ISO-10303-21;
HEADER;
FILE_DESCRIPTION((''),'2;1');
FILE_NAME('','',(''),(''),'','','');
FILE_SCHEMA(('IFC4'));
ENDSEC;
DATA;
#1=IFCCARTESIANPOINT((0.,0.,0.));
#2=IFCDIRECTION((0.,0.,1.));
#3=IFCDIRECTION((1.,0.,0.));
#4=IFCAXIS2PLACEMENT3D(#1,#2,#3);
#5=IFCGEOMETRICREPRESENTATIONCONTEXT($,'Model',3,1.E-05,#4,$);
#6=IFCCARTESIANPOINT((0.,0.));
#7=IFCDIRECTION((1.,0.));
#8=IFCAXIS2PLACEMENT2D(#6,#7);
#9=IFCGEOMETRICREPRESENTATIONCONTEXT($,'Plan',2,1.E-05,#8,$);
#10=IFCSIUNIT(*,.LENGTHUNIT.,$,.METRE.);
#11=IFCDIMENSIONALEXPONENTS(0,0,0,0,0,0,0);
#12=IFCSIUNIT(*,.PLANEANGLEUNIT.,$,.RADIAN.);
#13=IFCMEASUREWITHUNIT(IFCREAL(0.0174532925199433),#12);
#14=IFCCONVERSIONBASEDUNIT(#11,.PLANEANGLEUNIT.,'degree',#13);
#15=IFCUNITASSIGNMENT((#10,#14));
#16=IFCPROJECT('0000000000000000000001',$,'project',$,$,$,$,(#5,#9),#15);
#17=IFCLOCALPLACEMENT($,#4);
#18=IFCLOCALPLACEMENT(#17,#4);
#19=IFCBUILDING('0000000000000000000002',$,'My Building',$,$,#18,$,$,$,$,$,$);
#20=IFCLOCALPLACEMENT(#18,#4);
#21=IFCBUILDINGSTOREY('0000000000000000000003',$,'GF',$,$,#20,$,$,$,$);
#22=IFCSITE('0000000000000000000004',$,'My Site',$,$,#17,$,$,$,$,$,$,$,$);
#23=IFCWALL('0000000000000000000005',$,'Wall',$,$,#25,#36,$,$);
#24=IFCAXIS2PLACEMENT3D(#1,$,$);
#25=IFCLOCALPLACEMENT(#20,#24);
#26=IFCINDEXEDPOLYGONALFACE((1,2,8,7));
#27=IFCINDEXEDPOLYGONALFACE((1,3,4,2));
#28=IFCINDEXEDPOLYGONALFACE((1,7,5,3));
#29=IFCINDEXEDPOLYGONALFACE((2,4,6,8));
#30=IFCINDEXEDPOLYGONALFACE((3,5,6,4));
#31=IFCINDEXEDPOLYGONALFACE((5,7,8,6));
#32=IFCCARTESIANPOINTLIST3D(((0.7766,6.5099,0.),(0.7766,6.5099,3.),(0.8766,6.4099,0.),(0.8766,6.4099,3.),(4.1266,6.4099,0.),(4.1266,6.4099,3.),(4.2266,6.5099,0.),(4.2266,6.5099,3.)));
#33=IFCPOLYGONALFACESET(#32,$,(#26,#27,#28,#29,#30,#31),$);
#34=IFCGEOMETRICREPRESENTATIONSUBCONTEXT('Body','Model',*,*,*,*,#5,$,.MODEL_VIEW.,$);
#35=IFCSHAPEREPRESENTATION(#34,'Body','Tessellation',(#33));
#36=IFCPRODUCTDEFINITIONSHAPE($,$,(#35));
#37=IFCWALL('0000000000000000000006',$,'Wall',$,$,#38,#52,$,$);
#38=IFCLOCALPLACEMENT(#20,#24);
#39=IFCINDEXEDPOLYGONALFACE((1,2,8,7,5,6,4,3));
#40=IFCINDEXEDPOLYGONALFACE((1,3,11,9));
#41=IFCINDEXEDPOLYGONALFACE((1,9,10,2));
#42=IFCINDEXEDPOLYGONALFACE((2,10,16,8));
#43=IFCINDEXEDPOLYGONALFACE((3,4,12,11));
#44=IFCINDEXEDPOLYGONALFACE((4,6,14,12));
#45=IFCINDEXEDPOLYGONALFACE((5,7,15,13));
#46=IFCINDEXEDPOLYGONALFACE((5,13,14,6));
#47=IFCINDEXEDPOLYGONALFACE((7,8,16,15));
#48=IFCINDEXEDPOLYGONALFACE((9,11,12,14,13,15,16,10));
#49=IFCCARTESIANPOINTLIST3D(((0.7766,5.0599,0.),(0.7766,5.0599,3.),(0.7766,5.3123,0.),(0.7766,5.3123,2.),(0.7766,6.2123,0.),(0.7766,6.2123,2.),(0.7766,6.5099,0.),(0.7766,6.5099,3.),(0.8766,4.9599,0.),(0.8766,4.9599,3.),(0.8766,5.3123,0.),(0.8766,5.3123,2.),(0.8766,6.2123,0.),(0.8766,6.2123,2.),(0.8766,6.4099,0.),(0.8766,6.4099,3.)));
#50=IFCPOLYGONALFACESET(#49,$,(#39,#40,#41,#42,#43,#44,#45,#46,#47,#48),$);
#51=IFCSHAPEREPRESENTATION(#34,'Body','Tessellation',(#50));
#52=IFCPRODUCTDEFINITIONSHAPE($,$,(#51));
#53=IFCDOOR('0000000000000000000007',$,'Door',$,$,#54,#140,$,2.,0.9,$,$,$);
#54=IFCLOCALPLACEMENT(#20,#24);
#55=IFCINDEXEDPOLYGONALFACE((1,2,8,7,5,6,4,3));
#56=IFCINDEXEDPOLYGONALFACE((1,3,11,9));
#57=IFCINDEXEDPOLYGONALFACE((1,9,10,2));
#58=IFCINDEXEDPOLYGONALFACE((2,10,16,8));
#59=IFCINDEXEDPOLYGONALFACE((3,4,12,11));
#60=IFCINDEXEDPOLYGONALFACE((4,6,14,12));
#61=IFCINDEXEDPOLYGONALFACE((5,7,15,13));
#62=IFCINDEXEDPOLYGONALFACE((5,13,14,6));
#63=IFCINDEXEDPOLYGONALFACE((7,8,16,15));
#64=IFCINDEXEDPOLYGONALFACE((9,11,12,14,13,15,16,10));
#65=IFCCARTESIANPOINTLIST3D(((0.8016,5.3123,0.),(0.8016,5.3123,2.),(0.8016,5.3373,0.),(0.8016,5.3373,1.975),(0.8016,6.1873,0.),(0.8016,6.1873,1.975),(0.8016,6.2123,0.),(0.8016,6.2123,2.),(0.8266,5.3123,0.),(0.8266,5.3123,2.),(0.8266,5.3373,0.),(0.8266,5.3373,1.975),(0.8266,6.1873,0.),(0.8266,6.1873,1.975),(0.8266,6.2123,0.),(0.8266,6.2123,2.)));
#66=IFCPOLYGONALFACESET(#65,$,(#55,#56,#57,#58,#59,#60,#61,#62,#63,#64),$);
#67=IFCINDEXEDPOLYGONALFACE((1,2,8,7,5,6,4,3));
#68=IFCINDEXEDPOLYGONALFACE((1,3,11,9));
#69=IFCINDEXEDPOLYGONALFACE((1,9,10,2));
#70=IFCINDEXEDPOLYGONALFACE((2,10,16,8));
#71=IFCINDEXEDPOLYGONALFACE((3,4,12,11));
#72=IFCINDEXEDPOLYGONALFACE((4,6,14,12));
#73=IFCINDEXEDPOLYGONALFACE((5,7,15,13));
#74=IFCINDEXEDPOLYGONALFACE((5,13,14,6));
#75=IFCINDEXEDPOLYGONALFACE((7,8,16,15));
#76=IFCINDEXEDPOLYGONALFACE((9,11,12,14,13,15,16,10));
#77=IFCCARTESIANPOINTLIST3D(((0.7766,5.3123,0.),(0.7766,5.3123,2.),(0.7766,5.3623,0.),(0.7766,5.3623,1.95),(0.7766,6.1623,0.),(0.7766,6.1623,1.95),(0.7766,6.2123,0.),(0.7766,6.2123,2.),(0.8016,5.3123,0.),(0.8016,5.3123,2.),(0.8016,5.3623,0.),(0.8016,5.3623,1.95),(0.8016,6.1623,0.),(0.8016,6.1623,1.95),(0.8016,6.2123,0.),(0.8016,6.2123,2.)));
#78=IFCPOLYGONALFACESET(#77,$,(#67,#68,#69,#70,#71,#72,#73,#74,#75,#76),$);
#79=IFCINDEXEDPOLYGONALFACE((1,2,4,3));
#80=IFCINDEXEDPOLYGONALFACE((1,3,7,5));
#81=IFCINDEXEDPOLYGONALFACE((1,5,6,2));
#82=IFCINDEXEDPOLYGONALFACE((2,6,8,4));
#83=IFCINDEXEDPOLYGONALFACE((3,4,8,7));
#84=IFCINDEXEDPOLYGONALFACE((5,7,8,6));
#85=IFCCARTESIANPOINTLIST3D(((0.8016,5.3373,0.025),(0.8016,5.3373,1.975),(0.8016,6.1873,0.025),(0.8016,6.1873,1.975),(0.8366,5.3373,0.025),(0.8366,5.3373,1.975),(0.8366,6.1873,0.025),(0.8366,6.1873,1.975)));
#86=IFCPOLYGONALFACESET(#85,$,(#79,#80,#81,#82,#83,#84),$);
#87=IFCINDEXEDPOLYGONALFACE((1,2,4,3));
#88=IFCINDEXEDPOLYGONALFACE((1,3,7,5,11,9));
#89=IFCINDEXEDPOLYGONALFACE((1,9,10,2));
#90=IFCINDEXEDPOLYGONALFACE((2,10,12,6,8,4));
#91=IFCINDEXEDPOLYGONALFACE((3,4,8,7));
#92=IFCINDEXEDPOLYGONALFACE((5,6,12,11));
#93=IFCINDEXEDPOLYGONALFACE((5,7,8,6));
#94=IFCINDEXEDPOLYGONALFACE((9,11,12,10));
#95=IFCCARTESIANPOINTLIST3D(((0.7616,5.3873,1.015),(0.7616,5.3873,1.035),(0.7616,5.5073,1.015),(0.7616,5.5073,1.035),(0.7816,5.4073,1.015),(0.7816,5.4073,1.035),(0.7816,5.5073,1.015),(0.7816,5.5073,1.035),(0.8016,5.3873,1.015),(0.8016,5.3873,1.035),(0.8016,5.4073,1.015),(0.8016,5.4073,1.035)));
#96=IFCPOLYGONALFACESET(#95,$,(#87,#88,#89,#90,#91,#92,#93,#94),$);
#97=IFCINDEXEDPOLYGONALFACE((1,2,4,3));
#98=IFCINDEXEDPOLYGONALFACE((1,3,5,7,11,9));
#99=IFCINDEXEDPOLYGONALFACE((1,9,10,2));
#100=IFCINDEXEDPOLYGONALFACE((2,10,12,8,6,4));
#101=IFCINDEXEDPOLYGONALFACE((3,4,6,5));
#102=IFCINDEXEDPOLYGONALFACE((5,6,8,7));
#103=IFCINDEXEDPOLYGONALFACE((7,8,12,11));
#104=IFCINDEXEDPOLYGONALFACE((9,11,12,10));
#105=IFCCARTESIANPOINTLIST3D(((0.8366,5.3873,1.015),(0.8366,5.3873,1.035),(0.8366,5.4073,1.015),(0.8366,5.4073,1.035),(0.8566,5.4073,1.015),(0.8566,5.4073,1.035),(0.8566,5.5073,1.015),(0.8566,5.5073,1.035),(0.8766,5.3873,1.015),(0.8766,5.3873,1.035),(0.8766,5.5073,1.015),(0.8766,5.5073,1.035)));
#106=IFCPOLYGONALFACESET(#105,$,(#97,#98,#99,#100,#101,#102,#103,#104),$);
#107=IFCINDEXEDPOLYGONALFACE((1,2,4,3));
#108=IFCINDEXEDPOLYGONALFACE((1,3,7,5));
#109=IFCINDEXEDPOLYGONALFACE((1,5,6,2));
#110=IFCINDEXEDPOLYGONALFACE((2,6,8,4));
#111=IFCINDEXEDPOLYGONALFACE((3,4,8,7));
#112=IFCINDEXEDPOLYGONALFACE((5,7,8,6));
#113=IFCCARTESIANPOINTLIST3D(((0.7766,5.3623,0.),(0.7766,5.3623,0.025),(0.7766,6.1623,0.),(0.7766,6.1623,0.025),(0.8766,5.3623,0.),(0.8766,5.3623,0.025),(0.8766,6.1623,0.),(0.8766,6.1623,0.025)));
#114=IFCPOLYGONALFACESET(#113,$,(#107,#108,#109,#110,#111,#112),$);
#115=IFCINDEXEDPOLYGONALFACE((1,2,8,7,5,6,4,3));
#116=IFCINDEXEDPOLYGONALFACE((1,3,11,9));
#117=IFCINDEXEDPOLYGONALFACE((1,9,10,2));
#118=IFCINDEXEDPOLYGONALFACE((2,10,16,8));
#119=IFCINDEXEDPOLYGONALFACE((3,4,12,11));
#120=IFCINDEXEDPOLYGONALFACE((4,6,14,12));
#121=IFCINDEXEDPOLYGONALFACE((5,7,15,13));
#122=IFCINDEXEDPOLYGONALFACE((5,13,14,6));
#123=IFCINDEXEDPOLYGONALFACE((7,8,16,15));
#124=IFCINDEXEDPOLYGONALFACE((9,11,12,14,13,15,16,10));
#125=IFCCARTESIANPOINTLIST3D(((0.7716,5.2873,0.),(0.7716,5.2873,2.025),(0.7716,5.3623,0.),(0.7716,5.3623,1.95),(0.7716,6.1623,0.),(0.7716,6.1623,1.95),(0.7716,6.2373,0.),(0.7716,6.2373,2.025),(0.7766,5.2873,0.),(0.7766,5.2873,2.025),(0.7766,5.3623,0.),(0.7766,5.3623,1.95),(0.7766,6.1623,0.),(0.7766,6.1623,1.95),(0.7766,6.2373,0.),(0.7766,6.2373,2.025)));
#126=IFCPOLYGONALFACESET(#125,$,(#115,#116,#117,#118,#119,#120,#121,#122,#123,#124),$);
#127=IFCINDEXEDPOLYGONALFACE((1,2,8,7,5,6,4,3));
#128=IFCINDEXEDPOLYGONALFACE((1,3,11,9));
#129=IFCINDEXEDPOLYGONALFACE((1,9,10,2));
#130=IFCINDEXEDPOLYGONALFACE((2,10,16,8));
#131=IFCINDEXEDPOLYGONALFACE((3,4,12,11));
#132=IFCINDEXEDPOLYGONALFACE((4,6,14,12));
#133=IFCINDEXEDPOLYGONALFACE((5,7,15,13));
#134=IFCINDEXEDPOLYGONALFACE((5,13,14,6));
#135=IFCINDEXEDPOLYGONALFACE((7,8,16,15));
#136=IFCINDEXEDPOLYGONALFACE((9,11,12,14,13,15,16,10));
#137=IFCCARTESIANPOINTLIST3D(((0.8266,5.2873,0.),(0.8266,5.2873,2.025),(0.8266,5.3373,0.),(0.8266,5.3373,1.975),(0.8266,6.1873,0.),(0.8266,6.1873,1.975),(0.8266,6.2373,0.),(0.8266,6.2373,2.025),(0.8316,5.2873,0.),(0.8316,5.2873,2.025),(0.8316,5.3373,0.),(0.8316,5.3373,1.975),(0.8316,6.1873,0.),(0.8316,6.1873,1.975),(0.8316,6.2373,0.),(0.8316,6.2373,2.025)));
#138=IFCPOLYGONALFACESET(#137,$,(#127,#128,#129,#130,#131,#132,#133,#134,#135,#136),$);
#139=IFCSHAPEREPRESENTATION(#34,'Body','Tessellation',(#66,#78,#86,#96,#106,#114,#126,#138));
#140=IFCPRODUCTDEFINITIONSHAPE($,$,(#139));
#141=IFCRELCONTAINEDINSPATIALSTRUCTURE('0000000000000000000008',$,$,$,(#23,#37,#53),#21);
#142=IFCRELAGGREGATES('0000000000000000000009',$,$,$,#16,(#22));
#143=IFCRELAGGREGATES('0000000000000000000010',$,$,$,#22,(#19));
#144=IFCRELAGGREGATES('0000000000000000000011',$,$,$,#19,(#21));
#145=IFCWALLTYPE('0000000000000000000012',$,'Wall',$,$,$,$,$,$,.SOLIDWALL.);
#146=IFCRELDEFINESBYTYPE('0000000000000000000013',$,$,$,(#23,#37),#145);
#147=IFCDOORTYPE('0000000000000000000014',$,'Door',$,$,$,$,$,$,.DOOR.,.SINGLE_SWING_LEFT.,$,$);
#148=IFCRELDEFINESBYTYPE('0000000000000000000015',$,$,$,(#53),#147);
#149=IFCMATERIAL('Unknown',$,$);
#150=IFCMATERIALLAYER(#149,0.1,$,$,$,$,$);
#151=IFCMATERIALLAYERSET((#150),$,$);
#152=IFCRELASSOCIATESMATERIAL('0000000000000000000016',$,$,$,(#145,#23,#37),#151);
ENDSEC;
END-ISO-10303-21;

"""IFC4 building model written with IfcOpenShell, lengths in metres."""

from ifc_helpers import new_model, entity, si_unit, converted_unit, frame, origin_with_axes, origin_2d_with_axis, place, context, subcontext, project, spatial, line, indexed_curve, outline, extrude, shape, source, transform, mapped, material, layer, layer_set, layer_usage, type_object, type_shapes, element, fill, save


model = new_model("IFC4")

# Units and contexts
model_context = context("Model", 3, precision=1e-05, world=origin_with_axes())
plan_context = context("Plan", 2, precision=1e-05, world=origin_2d_with_axis())
body_context_1 = subcontext(model_context, "Body", "Model", "MODEL_VIEW")
body_context_2 = subcontext(plan_context, "Body", "Plan", "PLAN_VIEW")
ifc_project = project(units=[si_unit("LENGTHUNIT", "METRE"), converted_unit("PLANEANGLEUNIT", "degree", entity("IfcReal", 0.0174532925199433), si_unit("PLANEANGLEUNIT", "RADIAN"), dimensions=[0, 0, 0, 0, 0, 0, 0])], contexts=[model_context, plan_context])

# Site, building, storey
site_placement = place(None, origin_with_axes())
site = spatial("IfcSite", under=ifc_project, at=site_placement, Name="My Site")
building_placement = place(site_placement, origin_with_axes())
building = spatial("IfcBuilding", under=site, at=building_placement, Name="My Building")
storey_placement = place(building_placement, origin_with_axes())
storey = spatial("IfcBuildingStorey", under=building, at=storey_placement, Name="GF")

# Shared definitions
ifc_material = material(Name="Unknown")

# Wall
ifc_layer = layer(ifc_material, 0.1)
ifc_layer_set = layer_set([ifc_layer])
ifc_layer_usage_1 = layer_usage(ifc_layer_set, "AXIS2", "POSITIVE", 0.0)
wall_type = type_object("IfcWallType", Name="Wall", PredefinedType="SOLIDWALL", material=ifc_layer_set)
wall_1_placement = place(storey_placement, frame((4.2266, 6.5099, 0.0), z_axis=(0.0, 0.0, 1.0), x_axis=(-1.0, 0.0, 0.0)))
element("IfcWall", 1, at=wall_1_placement, inside=storey, type_object=wall_type, material=ifc_layer_usage_1, Name="Wall", context=body_context_1, shape_type="SweptSolid", body=[
    extrude(outline(indexed_curve([(0.0, 0.0), (0.1, 0.1), (3.35, 0.1), (3.45, 0.0)], segments=[line(1, 2, 3, 4, 1)])), origin_with_axes(), (0.0, 0.0, 1.0), 3.0),
])

# Wall, opening, door
ifc_layer_usage_2 = layer_usage(ifc_layer_set, "AXIS2", "POSITIVE", 0.0)
wall_2_placement = place(storey_placement, frame((0.7766, 6.5099, 0.0), z_axis=(0.0, 0.0, 1.0), x_axis=(0.0, -1.0, 0.0)))
wall_2 = element("IfcWall", 2, at=wall_2_placement, inside=storey, type_object=wall_type, material=ifc_layer_usage_2, Name="Wall", context=body_context_1, shape_type="SweptSolid", body=[
    extrude(outline(indexed_curve([(0.0, 0.0), (0.1, 0.1), (1.55, 0.1), (1.45, 0.0)], segments=[line(1, 2, 3, 4, 1)])), origin_with_axes(), (0.0, 0.0, 1.0), 3.0),
])
shared_shape_1 = source(origin_with_axes(), body_context_1, "Body", "SweptSolid", [
    extrude(outline(indexed_curve([(0.0, 0.0), (0.9, 0.0), (0.9, 2.0), (0.0, 2.0)], segments=[line(1, 2, 3, 4, 1)])), frame((0.0, -0.6, 0.0), z_axis=(0.0, -1.0, 0.0), x_axis=(1.0, 0.0, 0.0)), (0.0, 0.0, -1.0), 1.2),
])
opening_1_placement = place(wall_2_placement, frame((0.2976, 0.0, 0.0), z_axis=(0.0, 0.0, 1.0), x_axis=(1.0, 0.0, 0.0)))
opening_1 = element("IfcOpeningElement", 3, at=opening_1_placement, cuts=wall_2, PredefinedType="OPENING", context=body_context_1, shape_type="MappedRepresentation", body=[
    mapped(shared_shape_1, transform((0.0, 0.0, 0.0), x_axis=(1.0, 0.0, 0.0), y_axis=(0.0, 1.0, 0.0), z_axis=(0.0, 0.0, 1.0), scale=1.0)),
])
door_type = type_object("IfcDoorType", Name="Door", OperationType="SINGLE_SWING_LEFT", PredefinedType="DOOR")
shared_shape_2 = source(origin_with_axes(), body_context_1, "Body", "SweptSolid", [
    extrude(outline(indexed_curve([(0.0, 0.0), (0.0, 2.0), (0.9, 2.0), (0.9, 0.0), (0.875, 0.0), (0.875, 1.975), (0.025, 1.975), (0.025, 0.0)], segments=[line(1, 2, 3, 4, 5, 6, 7, 8, 1)])), frame((0.0, 0.025, 0.0), z_axis=(0.0, -1.0, 0.0), x_axis=(1.0, 0.0, 0.0)), (0.0, 0.0, -1.0), 0.025),
    extrude(outline(indexed_curve([(0.0, 0.0), (0.0, 2.0), (0.9, 2.0), (0.9, 0.0), (0.85, 0.0), (0.85, 1.95), (0.05, 1.95), (0.05, 0.0)], segments=[line(1, 2, 3, 4, 5, 6, 7, 8, 1)])), frame((0.0, 0.0, 0.0), z_axis=(0.0, -1.0, 0.0), x_axis=(1.0, 0.0, 0.0)), (0.0, 0.0, -1.0), 0.025),
    extrude(outline(indexed_curve([(0.0, 0.0), (0.85, 0.0), (0.85, 0.035), (0.0, 0.035)], segments=[line(1, 2, 3, 4, 1)])), frame((0.025, 0.025, 0.025), z_axis=(0.0, 0.0, 1.0), x_axis=(1.0, 0.0, 0.0)), (0.0, 0.0, 1.0), 1.95),
    extrude(outline(indexed_curve([(0.0, 0.0), (0.0, -0.04), (-0.12, -0.04), (-0.12, -0.02), (-0.02, -0.02), (-0.02, 0.0)], segments=[line(1, 2, 3, 4, 5, 6, 1)])), frame((0.825, 0.025, 1.015), z_axis=(0.0, 0.0, 1.0), x_axis=(1.0, 0.0, 0.0)), (0.0, 0.0, 1.0), 0.02),
    extrude(outline(indexed_curve([(0.0, 0.0), (0.0, 0.04), (-0.12, 0.04), (-0.12, 0.02), (-0.02, 0.02), (-0.02, 0.0)], segments=[line(1, 2, 3, 4, 5, 6, 1)])), frame((0.825, 0.06, 1.015), z_axis=(0.0, 0.0, 1.0), x_axis=(1.0, 0.0, 0.0)), (0.0, 0.0, 1.0), 0.02),
    extrude(outline(indexed_curve([(0.0, 0.0), (0.8, 0.0), (0.8, 0.1), (0.0, 0.1)], segments=[line(1, 2, 3, 4, 1)])), frame((0.05, 0.0, 0.0), z_axis=(0.0, 0.0, 1.0), x_axis=(1.0, 0.0, 0.0)), (0.0, 0.0, 1.0), 0.025),
    extrude(outline(indexed_curve([(0.0, 0.0), (0.0, 2.025), (0.95, 2.025), (0.95, 0.0), (0.875, 0.0), (0.875, 1.95), (0.075, 1.95), (0.075, 0.0)], segments=[line(1, 2, 3, 4, 5, 6, 7, 8, 1)])), frame((-0.025, -0.005, 0.0), z_axis=(0.0, -1.0, 0.0), x_axis=(1.0, 0.0, 0.0)), (0.0, 0.0, -1.0), 0.005),
    extrude(outline(indexed_curve([(0.0, 0.0), (0.0, 2.025), (0.95, 2.025), (0.95, 0.0), (0.9, 0.0), (0.9, 1.975), (0.05, 1.975), (0.05, 0.0)], segments=[line(1, 2, 3, 4, 5, 6, 7, 8, 1)])), frame((-0.025, 0.05, 0.0), z_axis=(0.0, -1.0, 0.0), x_axis=(1.0, 0.0, 0.0)), (0.0, 0.0, -1.0), 0.005),
])
shared_shape_3 = source(origin_with_axes(), body_context_2, "Body", "Curve2D", [
    entity("IfcIndexedPolyCurve", entity("IfcCartesianPointList2D", [[0.0, 0.0], [0.0, 0.05], [0.025, 0.05], [0.025, 0.025], [0.05, 0.025], [0.05, 0.0]]), [entity("IfcLineIndex", [1, 2, 3, 4, 5, 6, 1])]),
    entity("IfcIndexedPolyCurve", entity("IfcCartesianPointList2D", [[0.9, 0.0], [0.9, 0.05], [0.875, 0.05], [0.875, 0.025], [0.85, 0.025], [0.85, 0.0]]), [entity("IfcLineIndex", [1, 2, 3, 4, 5, 6, 1])]),
    entity("IfcTrimmedCurve", entity("IfcEllipse", entity("IfcAxis2Placement2D", entity("IfcCartesianPoint", [0.06, 0.05]), entity("IfcDirection", [1.0, 0.0])), 0.815, 0.85), [entity("IfcCartesianPoint", [0.875, 0.05])], [entity("IfcCartesianPoint", [0.06, 0.9])], True, "CARTESIAN"),
    entity("IfcIndexedPolyCurve", entity("IfcCartesianPointList2D", [[0.025, 0.05], [0.06, 0.05], [0.06, 0.9], [0.025, 0.9]]), [entity("IfcLineIndex", [1, 2, 3, 4, 1])]),
])
type_shapes(door_type, [shared_shape_2, shared_shape_3])
door_1_placement = place(opening_1_placement, frame((0.0, 0.0, 0.0), z_axis=(0.0, 0.0, 1.0), x_axis=(1.0, 0.0, 0.0)))
door_1 = element("IfcDoor", 4, at=door_1_placement, inside=storey, type_object=door_type, Name="Door", OverallHeight=2.0, OverallWidth=0.9, shapes=[
    shape(body_context_1, "Body", "MappedRepresentation", [mapped(shared_shape_2, transform((0.0, 0.0, 0.0), x_axis=(1.0, 0.0, 0.0), y_axis=(0.0, 1.0, 0.0), z_axis=(0.0, 0.0, 1.0), scale=1.0))]),
    shape(body_context_2, "Body", "MappedRepresentation", [mapped(shared_shape_3, transform((0.0, 0.0, 0.0), x_axis=(1.0, 0.0, 0.0), y_axis=(0.0, 1.0, 0.0), z_axis=(0.0, 0.0, 1.0), scale=1.0))]),
])
fill(opening_1, door_1)

save(model, "model.ifc")
